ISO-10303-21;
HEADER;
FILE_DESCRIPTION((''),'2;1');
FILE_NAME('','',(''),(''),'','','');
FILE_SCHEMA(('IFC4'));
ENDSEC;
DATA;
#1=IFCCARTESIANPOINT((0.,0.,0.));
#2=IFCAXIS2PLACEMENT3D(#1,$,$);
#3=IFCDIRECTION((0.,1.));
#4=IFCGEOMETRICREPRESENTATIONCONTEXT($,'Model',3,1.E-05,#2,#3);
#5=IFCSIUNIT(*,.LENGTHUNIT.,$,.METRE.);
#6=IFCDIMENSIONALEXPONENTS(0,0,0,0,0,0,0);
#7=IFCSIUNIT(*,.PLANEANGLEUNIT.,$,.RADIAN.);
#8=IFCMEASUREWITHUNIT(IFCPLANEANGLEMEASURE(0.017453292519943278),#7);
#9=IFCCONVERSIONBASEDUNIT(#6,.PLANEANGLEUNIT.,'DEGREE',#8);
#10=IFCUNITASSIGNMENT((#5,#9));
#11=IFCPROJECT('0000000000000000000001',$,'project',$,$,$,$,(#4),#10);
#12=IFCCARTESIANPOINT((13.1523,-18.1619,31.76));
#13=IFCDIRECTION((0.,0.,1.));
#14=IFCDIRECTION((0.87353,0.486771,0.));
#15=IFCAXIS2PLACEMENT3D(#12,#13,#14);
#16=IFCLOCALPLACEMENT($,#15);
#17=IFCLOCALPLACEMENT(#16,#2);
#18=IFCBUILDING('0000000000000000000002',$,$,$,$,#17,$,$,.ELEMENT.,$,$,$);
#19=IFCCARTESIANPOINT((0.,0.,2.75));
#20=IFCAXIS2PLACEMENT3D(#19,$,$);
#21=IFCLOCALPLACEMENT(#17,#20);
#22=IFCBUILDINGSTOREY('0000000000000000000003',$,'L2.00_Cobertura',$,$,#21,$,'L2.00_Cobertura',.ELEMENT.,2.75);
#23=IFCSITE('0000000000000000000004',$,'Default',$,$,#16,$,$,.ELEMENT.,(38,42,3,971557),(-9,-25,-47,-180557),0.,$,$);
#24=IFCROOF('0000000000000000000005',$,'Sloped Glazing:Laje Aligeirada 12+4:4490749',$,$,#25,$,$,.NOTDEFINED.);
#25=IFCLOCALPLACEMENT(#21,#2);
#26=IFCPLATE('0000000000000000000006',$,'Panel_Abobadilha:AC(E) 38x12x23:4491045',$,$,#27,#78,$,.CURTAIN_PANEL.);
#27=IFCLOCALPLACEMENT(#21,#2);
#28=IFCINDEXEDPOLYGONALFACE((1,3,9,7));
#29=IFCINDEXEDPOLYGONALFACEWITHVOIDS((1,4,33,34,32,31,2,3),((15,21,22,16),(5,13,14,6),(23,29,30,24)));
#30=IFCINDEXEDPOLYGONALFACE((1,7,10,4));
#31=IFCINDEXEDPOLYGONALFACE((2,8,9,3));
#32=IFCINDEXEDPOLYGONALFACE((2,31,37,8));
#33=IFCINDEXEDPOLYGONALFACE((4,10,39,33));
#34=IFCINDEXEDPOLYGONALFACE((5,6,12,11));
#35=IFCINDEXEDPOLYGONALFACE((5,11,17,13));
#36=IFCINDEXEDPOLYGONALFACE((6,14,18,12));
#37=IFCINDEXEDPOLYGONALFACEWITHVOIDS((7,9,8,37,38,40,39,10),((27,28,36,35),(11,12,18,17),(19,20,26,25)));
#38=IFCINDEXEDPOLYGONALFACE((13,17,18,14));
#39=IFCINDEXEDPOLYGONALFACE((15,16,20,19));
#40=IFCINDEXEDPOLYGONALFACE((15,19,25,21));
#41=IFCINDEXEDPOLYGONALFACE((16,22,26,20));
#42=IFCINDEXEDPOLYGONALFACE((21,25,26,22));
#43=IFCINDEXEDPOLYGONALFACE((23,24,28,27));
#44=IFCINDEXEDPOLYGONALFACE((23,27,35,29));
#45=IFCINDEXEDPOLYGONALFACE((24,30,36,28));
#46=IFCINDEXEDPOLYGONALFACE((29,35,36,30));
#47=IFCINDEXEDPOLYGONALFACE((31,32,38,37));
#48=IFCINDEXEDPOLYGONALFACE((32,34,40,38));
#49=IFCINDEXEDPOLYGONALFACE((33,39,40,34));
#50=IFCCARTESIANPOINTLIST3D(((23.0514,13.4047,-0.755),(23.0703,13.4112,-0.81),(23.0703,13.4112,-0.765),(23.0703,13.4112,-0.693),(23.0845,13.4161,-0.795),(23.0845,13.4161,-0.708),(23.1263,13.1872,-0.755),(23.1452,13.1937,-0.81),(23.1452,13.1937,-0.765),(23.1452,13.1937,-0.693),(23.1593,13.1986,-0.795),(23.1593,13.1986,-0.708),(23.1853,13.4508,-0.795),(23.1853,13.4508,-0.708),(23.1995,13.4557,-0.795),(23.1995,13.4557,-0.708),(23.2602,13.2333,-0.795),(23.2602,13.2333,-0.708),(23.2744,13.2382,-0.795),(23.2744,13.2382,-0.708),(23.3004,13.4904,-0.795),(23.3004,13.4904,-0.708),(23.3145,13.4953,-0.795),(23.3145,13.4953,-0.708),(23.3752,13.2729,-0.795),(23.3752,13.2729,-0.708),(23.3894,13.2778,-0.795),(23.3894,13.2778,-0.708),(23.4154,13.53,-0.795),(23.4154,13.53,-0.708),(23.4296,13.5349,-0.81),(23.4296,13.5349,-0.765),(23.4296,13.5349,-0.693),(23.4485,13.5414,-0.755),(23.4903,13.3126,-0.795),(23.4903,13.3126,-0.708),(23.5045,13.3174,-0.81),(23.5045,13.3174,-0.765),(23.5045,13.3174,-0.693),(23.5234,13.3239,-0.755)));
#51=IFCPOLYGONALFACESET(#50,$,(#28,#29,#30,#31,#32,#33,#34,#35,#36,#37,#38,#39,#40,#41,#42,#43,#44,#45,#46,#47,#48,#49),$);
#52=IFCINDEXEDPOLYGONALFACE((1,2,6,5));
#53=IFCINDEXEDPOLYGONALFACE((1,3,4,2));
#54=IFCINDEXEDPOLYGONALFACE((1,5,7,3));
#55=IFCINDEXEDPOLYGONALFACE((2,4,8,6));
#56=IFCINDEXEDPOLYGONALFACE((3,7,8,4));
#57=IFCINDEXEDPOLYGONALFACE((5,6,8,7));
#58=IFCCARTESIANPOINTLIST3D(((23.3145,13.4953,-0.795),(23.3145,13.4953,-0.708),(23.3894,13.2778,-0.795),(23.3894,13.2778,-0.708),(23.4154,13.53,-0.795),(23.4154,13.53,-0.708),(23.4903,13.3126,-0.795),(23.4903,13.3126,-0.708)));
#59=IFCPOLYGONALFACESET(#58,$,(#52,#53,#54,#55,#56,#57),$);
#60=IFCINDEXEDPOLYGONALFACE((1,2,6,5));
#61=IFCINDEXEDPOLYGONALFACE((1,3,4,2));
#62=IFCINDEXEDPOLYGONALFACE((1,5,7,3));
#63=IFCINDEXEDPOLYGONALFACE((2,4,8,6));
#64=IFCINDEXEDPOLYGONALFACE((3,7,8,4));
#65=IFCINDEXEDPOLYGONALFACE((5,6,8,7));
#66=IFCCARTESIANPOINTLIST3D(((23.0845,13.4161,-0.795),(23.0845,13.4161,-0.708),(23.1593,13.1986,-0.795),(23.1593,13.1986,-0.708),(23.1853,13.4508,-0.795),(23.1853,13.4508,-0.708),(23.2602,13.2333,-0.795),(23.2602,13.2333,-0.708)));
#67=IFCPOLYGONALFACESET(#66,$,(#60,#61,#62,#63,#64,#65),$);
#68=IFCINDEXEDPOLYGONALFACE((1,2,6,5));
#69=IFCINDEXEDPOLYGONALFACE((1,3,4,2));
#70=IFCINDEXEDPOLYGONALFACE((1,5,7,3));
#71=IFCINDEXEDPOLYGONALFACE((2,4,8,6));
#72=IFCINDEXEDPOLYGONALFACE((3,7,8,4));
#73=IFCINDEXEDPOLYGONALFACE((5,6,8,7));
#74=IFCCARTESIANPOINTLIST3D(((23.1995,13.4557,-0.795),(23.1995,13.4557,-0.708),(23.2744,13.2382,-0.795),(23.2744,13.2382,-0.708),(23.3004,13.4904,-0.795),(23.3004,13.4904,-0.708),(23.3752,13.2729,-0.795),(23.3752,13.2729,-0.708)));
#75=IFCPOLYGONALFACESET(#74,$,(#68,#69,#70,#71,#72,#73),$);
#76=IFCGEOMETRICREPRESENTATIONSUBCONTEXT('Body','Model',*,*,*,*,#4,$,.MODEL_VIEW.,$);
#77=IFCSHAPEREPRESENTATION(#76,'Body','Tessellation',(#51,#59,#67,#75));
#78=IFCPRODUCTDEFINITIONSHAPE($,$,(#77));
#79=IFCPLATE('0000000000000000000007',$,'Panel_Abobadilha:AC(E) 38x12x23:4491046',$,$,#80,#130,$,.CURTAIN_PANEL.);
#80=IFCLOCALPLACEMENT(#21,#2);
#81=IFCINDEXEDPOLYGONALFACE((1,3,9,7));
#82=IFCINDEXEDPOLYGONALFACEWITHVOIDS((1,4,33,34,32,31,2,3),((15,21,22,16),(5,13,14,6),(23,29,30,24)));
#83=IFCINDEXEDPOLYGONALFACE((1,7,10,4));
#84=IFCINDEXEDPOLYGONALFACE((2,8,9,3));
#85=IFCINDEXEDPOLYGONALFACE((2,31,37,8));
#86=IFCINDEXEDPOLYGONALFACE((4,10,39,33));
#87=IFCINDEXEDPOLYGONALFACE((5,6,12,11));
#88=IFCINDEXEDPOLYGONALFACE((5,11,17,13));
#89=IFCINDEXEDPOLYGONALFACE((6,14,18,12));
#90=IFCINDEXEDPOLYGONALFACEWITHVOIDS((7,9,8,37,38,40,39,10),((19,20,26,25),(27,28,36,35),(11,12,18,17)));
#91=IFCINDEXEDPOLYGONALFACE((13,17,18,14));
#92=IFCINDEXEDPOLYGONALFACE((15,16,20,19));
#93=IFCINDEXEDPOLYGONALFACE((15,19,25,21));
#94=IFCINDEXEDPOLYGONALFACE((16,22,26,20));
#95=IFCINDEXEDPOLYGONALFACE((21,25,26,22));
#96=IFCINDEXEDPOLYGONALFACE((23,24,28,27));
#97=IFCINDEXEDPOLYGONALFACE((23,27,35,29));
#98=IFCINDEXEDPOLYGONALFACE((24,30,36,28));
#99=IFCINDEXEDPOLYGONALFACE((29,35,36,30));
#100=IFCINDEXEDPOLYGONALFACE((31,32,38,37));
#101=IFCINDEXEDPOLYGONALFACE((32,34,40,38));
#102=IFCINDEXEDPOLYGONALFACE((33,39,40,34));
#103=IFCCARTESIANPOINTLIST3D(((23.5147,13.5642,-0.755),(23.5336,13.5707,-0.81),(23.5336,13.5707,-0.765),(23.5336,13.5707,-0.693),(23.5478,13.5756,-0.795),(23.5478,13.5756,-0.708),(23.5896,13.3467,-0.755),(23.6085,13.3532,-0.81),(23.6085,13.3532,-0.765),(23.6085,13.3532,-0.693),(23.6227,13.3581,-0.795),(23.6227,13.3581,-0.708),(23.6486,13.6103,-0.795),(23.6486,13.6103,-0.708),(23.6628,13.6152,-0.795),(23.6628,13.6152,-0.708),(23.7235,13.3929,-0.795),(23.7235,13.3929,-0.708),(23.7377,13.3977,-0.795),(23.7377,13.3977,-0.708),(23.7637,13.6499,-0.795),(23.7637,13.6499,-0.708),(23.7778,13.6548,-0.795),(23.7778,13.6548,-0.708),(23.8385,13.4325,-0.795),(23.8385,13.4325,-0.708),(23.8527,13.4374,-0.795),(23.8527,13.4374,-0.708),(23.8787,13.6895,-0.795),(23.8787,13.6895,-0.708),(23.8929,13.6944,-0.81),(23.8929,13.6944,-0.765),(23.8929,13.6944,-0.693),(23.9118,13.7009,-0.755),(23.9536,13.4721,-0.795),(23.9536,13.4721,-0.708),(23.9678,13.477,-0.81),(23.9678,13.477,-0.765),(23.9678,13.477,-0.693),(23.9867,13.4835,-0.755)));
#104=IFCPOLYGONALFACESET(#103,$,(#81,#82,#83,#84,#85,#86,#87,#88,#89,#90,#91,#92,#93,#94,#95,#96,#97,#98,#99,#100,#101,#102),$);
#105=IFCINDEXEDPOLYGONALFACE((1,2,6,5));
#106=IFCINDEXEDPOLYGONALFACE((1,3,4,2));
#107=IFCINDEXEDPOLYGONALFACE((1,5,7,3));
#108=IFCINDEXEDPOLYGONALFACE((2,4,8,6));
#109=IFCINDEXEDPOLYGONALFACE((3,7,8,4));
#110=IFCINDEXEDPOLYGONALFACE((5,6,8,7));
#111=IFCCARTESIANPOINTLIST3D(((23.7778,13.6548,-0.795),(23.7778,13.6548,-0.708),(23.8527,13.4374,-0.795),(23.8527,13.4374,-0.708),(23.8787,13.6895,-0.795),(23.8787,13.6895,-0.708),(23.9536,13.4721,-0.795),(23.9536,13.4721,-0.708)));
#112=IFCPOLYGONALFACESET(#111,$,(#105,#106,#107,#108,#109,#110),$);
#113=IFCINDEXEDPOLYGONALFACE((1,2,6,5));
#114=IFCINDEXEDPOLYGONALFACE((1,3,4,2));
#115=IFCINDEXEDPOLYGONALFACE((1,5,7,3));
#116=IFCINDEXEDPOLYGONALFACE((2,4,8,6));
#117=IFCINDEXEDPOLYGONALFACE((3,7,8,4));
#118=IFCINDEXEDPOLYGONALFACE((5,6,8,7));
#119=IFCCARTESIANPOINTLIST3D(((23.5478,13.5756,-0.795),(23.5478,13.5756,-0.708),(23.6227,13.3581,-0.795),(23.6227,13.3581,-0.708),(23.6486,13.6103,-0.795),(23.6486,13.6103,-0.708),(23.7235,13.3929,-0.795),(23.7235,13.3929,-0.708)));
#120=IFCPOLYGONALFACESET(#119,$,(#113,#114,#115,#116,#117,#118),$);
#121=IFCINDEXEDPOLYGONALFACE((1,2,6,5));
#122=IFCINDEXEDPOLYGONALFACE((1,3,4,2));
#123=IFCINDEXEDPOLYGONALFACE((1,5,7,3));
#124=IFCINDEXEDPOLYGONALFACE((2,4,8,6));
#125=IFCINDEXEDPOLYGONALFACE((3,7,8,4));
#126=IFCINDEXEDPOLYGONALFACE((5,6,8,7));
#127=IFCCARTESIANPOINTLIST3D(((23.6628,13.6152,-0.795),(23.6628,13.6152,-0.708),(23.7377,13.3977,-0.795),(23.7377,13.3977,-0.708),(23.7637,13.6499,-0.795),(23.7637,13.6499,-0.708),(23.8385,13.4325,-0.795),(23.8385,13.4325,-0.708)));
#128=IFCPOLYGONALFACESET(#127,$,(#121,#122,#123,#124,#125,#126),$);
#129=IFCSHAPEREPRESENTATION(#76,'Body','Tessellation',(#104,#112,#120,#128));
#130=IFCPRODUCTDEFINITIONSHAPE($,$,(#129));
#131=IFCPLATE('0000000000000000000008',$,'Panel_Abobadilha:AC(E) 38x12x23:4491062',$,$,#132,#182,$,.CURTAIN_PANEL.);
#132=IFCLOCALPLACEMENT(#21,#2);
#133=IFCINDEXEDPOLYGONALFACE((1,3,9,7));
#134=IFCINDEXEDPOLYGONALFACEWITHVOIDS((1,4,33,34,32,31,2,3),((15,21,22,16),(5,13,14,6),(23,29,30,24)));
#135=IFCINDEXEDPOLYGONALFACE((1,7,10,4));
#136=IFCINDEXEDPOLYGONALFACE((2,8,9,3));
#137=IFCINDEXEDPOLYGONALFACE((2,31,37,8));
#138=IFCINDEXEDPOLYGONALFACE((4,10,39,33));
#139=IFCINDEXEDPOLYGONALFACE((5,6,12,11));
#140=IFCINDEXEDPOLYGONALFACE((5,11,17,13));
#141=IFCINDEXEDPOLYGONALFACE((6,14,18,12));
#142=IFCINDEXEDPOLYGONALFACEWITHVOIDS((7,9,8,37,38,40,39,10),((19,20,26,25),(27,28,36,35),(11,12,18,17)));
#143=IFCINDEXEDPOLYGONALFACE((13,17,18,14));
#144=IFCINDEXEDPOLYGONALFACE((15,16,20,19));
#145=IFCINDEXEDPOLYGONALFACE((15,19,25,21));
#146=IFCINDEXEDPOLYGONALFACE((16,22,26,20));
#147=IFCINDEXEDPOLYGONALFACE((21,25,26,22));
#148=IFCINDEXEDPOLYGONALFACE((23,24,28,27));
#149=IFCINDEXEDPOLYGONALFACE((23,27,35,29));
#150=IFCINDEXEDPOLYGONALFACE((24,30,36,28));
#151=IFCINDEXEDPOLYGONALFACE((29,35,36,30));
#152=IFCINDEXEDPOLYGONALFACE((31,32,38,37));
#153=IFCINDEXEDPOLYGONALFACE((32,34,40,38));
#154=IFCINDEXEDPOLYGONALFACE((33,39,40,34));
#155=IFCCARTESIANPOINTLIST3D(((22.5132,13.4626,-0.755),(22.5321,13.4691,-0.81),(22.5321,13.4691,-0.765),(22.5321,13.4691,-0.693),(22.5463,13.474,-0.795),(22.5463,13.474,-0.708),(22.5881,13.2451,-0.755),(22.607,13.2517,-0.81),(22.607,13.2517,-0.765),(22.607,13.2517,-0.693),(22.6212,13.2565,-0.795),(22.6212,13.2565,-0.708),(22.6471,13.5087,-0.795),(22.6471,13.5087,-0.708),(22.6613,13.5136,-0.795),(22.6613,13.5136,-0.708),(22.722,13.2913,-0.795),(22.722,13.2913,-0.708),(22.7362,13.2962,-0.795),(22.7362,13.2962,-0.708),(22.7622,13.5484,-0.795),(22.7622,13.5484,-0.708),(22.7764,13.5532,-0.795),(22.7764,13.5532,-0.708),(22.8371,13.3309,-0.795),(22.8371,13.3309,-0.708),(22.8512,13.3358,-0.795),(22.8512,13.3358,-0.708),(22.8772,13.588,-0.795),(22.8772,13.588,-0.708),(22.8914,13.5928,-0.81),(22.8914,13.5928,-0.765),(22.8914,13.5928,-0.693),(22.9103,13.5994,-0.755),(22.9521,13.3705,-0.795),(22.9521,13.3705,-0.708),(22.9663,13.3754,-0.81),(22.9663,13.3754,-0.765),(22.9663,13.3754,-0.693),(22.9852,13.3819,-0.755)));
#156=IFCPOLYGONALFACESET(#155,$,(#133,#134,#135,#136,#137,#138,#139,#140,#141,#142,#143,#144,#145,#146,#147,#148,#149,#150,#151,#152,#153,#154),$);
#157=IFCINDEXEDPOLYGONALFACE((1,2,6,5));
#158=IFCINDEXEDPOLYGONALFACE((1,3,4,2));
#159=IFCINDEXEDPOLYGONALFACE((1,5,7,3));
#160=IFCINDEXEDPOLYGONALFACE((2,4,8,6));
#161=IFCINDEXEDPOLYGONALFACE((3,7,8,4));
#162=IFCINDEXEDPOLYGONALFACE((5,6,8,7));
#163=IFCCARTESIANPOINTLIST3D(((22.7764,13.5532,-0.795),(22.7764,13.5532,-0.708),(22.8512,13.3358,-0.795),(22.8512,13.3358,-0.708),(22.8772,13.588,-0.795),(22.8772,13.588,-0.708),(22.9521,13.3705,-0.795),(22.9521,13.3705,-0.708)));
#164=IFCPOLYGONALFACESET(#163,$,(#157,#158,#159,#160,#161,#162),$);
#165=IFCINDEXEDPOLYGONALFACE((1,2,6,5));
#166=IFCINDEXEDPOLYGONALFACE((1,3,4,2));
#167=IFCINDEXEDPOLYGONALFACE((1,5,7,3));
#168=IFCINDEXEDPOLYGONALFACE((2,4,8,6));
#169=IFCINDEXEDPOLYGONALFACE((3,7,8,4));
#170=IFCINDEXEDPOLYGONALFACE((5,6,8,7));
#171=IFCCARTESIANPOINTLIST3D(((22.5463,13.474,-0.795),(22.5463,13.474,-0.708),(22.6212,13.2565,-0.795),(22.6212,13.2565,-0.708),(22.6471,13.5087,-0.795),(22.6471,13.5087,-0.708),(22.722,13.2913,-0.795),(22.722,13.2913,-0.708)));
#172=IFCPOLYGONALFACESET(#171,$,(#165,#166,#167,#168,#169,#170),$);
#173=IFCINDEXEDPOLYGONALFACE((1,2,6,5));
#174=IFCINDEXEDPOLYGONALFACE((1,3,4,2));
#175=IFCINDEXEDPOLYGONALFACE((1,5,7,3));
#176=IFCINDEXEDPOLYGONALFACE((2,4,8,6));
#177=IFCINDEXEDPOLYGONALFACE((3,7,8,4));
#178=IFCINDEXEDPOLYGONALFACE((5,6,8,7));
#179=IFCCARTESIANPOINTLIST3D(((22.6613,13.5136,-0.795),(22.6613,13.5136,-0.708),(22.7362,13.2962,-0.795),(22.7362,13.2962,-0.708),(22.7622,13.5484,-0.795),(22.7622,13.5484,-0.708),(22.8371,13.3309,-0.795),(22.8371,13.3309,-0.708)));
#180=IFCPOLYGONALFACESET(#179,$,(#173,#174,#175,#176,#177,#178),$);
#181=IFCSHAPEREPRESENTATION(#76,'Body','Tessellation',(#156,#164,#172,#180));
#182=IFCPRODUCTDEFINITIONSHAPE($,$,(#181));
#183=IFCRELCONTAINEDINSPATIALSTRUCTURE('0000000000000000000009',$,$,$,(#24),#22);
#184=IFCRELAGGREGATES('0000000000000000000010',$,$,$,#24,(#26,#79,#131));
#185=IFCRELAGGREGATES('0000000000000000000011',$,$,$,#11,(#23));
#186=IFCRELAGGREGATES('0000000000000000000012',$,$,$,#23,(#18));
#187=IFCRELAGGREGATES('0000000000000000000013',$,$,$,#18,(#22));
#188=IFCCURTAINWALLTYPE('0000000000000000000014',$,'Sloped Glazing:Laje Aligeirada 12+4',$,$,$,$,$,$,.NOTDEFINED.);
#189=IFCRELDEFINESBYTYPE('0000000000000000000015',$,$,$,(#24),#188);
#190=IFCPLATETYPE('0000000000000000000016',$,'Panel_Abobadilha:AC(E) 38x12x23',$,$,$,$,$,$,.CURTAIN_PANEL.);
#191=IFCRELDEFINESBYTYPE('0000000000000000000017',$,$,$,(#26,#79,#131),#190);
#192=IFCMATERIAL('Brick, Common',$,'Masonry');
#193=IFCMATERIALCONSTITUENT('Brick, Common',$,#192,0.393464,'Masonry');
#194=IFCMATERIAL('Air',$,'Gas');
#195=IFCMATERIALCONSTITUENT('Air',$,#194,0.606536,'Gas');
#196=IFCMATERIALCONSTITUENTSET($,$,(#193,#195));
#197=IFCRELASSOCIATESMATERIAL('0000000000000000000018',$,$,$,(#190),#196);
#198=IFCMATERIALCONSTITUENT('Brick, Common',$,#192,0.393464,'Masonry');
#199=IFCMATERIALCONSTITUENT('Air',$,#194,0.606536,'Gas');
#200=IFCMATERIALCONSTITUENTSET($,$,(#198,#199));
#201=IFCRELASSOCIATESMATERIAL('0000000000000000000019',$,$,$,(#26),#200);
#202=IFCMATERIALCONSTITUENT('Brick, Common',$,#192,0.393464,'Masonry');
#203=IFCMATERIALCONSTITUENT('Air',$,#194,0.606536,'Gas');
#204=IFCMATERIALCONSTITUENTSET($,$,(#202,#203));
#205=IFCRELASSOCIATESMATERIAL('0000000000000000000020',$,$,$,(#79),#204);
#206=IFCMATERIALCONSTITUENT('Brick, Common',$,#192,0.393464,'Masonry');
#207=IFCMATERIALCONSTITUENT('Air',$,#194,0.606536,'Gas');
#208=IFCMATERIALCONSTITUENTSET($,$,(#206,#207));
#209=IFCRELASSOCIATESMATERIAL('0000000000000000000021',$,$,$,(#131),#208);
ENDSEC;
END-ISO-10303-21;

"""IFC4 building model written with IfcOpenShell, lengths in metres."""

from ifc_helpers import new_model, entity, si_unit, converted_unit, direction, frame, origin, place, context, subcontext, project, spatial, indexed_curve, outline, extrude, source, transform, mapped, material, constituent, constituent_set, type_object, type_shapes, element, aggregate, save


model = new_model("IFC4")

# Units and contexts
model_context = context("Model", 3, precision=1e-05, world=origin(), true_north=direction((0.0, 1.0)))
body_context = subcontext(model_context, "Body", "Model", "MODEL_VIEW")
ifc_project = project(units=[si_unit("LENGTHUNIT", "METRE"), converted_unit("PLANEANGLEUNIT", "DEGREE", entity("IfcPlaneAngleMeasure", 0.017453292519943278), si_unit("PLANEANGLEUNIT", "RADIAN"), dimensions=[0, 0, 0, 0, 0, 0, 0])], contexts=[model_context])

# Site, building, storey
site_placement = place(None, frame((13.1523, -18.1619, 31.76), z_axis=(0.0, 0.0, 1.0), x_axis=(0.87353, 0.486771, 0.0)))
site = spatial("IfcSite", under=ifc_project, at=site_placement, Name="Default", CompositionType="ELEMENT", RefLatitude=(38, 42, 3, 971557), RefLongitude=(-9, -25, -47, -180557), RefElevation=0.0)
building_placement = place(site_placement, origin())
building = spatial("IfcBuilding", under=site, at=building_placement, CompositionType="ELEMENT")
storey_placement = place(building_placement, frame((0.0, 0.0, 2.75)))
storey = spatial("IfcBuildingStorey", under=building, at=storey_placement, Name="L2.00_Cobertura", LongName="L2.00_Cobertura", CompositionType="ELEMENT", Elevation=2.75)

# Roof, plates
curtain_wall_type = type_object("IfcCurtainWallType", Name="Sloped Glazing:Laje Aligeirada 12+4", PredefinedType="NOTDEFINED")
roof_placement = place(storey_placement, frame((0.0, 0.0, -2.75)))
roof = element("IfcRoof", 1, at=roof_placement, inside=storey, type_object=curtain_wall_type, Name="Sloped Glazing:Laje Aligeirada 12+4:4490749", PredefinedType="NOTDEFINED")
ifc_material_1 = material(Name="Brick, Common", Category="Masonry")
ifc_material_2 = material(Name="Air", Category="Gas")
ifc_constituent_1 = constituent(ifc_material_1, Name="Brick, Common", Category="Masonry", fraction=0.393464)
ifc_constituent_2 = constituent(ifc_material_2, Name="Air", Category="Gas", fraction=0.606536)
ifc_constituent_set_1 = constituent_set(constituents=[ifc_constituent_1, ifc_constituent_2])
plate_type = type_object("IfcPlateType", Name="Panel_Abobadilha:AC(E) 38x12x23", PredefinedType="CURTAIN_PANEL", material=ifc_constituent_set_1)
shared_shape_1 = source(origin(), body_context, "Body", "SweptSolid", [
    extrude(outline(indexed_curve([(-0.19, -0.0543), (0.19, -0.0543), (0.19, -0.0093), (0.21, 0.0007), (0.19, 0.0628), (-0.19, 0.0628), (-0.21, 0.0007), (-0.19, -0.0093), (-0.19, -0.0543)], self_intersect=False), holes=[indexed_curve([(-0.0683, 0.0477), (-0.0683, -0.0393), (-0.175, -0.0393), (-0.175, 0.0477), (-0.0683, 0.0477)], self_intersect=False), indexed_curve([(0.0533, 0.0477), (0.0533, -0.0393), (-0.0533, -0.0393), (-0.0533, 0.0477), (0.0533, 0.0477)], self_intersect=False), indexed_curve([(0.175, 0.0477), (0.175, -0.0393), (0.0683, -0.0393), (0.0683, 0.0477), (0.175, 0.0477)], self_intersect=False)]), frame((0.0, 0.0543, 0.0)), (0.0, 0.0, 1.0), 0.23),
    extrude(outline(indexed_curve([(-0.0533, -0.0435), (0.0533, -0.0435), (0.0533, 0.0435), (-0.0533, 0.0435), (-0.0533, -0.0435)], self_intersect=False)), frame((0.1217, 0.0585, 0.0), z_axis=(0.0, 0.0, 1.0), x_axis=(-1.0, 0.0, 0.0)), (0.0, 0.0, 1.0), 0.23),
    extrude(outline(indexed_curve([(-0.0533, -0.0435), (0.0533, -0.0435), (0.0533, 0.0435), (-0.0533, 0.0435), (-0.0533, -0.0435)], self_intersect=False)), frame((-0.1217, 0.0585, 0.0), z_axis=(0.0, 0.0, 1.0), x_axis=(-1.0, 0.0, 0.0)), (0.0, 0.0, 1.0), 0.23),
    extrude(outline(indexed_curve([(-0.0533, -0.0435), (0.0533, -0.0435), (0.0533, 0.0435), (-0.0533, 0.0435), (-0.0533, -0.0435)], self_intersect=False)), frame((0.0, 0.0585, 0.0), z_axis=(0.0, 0.0, 1.0), x_axis=(-1.0, 0.0, 0.0)), (0.0, 0.0, 1.0), 0.23),
])
type_shapes(plate_type, [shared_shape_1])
ifc_constituent_3 = constituent(ifc_material_1, Name="Brick, Common", Category="Masonry", fraction=0.393464)
ifc_constituent_4 = constituent(ifc_material_2, Name="Air", Category="Gas", fraction=0.606536)
ifc_constituent_set_2 = constituent_set(constituents=[ifc_constituent_3, ifc_constituent_4])
plate_1_placement = place(roof_placement, frame((23.2499, 13.473, 1.94), z_axis=(0.325568, -0.945519, 0.0), x_axis=(0.945519, 0.325568, 0.0)))
plate_1 = element("IfcPlate", 2, at=plate_1_placement, type_object=plate_type, material=ifc_constituent_set_2, Name="Panel_Abobadilha:AC(E) 38x12x23:4491045", PredefinedType="CURTAIN_PANEL", context=body_context, shape_type="MappedRepresentation", body=[
    mapped(shared_shape_1, transform((0.0, 0.0, 0.0), scale=1.0)),
])
ifc_constituent_5 = constituent(ifc_material_1, Name="Brick, Common", Category="Masonry", fraction=0.393464)
ifc_constituent_6 = constituent(ifc_material_2, Name="Air", Category="Gas", fraction=0.606536)
ifc_constituent_set_3 = constituent_set(constituents=[ifc_constituent_5, ifc_constituent_6])
plate_2_placement = place(roof_placement, frame((23.7132, 13.6326, 1.94), z_axis=(0.325568, -0.945519, 0.0), x_axis=(0.945519, 0.325568, 0.0)))
plate_2 = element("IfcPlate", 3, at=plate_2_placement, type_object=plate_type, material=ifc_constituent_set_3, Name="Panel_Abobadilha:AC(E) 38x12x23:4491046", PredefinedType="CURTAIN_PANEL", context=body_context, shape_type="MappedRepresentation", body=[
    mapped(shared_shape_1, transform((0.0, 0.0, 0.0), scale=1.0)),
])
ifc_constituent_7 = constituent(ifc_material_1, Name="Brick, Common", Category="Masonry", fraction=0.393464)
ifc_constituent_8 = constituent(ifc_material_2, Name="Air", Category="Gas", fraction=0.606536)
ifc_constituent_set_4 = constituent_set(constituents=[ifc_constituent_7, ifc_constituent_8])
plate_3_placement = place(roof_placement, frame((22.7117, 13.531, 1.94), z_axis=(0.325568, -0.945519, 0.0), x_axis=(0.945519, 0.325568, 0.0)))
plate_3 = element("IfcPlate", 4, at=plate_3_placement, type_object=plate_type, material=ifc_constituent_set_4, Name="Panel_Abobadilha:AC(E) 38x12x23:4491062", PredefinedType="CURTAIN_PANEL", context=body_context, shape_type="MappedRepresentation", body=[
    mapped(shared_shape_1, transform((0.0, 0.0, 0.0), scale=1.0)),
])
aggregate(roof, [plate_1, plate_2, plate_3])

save(model, "model.ifc")
